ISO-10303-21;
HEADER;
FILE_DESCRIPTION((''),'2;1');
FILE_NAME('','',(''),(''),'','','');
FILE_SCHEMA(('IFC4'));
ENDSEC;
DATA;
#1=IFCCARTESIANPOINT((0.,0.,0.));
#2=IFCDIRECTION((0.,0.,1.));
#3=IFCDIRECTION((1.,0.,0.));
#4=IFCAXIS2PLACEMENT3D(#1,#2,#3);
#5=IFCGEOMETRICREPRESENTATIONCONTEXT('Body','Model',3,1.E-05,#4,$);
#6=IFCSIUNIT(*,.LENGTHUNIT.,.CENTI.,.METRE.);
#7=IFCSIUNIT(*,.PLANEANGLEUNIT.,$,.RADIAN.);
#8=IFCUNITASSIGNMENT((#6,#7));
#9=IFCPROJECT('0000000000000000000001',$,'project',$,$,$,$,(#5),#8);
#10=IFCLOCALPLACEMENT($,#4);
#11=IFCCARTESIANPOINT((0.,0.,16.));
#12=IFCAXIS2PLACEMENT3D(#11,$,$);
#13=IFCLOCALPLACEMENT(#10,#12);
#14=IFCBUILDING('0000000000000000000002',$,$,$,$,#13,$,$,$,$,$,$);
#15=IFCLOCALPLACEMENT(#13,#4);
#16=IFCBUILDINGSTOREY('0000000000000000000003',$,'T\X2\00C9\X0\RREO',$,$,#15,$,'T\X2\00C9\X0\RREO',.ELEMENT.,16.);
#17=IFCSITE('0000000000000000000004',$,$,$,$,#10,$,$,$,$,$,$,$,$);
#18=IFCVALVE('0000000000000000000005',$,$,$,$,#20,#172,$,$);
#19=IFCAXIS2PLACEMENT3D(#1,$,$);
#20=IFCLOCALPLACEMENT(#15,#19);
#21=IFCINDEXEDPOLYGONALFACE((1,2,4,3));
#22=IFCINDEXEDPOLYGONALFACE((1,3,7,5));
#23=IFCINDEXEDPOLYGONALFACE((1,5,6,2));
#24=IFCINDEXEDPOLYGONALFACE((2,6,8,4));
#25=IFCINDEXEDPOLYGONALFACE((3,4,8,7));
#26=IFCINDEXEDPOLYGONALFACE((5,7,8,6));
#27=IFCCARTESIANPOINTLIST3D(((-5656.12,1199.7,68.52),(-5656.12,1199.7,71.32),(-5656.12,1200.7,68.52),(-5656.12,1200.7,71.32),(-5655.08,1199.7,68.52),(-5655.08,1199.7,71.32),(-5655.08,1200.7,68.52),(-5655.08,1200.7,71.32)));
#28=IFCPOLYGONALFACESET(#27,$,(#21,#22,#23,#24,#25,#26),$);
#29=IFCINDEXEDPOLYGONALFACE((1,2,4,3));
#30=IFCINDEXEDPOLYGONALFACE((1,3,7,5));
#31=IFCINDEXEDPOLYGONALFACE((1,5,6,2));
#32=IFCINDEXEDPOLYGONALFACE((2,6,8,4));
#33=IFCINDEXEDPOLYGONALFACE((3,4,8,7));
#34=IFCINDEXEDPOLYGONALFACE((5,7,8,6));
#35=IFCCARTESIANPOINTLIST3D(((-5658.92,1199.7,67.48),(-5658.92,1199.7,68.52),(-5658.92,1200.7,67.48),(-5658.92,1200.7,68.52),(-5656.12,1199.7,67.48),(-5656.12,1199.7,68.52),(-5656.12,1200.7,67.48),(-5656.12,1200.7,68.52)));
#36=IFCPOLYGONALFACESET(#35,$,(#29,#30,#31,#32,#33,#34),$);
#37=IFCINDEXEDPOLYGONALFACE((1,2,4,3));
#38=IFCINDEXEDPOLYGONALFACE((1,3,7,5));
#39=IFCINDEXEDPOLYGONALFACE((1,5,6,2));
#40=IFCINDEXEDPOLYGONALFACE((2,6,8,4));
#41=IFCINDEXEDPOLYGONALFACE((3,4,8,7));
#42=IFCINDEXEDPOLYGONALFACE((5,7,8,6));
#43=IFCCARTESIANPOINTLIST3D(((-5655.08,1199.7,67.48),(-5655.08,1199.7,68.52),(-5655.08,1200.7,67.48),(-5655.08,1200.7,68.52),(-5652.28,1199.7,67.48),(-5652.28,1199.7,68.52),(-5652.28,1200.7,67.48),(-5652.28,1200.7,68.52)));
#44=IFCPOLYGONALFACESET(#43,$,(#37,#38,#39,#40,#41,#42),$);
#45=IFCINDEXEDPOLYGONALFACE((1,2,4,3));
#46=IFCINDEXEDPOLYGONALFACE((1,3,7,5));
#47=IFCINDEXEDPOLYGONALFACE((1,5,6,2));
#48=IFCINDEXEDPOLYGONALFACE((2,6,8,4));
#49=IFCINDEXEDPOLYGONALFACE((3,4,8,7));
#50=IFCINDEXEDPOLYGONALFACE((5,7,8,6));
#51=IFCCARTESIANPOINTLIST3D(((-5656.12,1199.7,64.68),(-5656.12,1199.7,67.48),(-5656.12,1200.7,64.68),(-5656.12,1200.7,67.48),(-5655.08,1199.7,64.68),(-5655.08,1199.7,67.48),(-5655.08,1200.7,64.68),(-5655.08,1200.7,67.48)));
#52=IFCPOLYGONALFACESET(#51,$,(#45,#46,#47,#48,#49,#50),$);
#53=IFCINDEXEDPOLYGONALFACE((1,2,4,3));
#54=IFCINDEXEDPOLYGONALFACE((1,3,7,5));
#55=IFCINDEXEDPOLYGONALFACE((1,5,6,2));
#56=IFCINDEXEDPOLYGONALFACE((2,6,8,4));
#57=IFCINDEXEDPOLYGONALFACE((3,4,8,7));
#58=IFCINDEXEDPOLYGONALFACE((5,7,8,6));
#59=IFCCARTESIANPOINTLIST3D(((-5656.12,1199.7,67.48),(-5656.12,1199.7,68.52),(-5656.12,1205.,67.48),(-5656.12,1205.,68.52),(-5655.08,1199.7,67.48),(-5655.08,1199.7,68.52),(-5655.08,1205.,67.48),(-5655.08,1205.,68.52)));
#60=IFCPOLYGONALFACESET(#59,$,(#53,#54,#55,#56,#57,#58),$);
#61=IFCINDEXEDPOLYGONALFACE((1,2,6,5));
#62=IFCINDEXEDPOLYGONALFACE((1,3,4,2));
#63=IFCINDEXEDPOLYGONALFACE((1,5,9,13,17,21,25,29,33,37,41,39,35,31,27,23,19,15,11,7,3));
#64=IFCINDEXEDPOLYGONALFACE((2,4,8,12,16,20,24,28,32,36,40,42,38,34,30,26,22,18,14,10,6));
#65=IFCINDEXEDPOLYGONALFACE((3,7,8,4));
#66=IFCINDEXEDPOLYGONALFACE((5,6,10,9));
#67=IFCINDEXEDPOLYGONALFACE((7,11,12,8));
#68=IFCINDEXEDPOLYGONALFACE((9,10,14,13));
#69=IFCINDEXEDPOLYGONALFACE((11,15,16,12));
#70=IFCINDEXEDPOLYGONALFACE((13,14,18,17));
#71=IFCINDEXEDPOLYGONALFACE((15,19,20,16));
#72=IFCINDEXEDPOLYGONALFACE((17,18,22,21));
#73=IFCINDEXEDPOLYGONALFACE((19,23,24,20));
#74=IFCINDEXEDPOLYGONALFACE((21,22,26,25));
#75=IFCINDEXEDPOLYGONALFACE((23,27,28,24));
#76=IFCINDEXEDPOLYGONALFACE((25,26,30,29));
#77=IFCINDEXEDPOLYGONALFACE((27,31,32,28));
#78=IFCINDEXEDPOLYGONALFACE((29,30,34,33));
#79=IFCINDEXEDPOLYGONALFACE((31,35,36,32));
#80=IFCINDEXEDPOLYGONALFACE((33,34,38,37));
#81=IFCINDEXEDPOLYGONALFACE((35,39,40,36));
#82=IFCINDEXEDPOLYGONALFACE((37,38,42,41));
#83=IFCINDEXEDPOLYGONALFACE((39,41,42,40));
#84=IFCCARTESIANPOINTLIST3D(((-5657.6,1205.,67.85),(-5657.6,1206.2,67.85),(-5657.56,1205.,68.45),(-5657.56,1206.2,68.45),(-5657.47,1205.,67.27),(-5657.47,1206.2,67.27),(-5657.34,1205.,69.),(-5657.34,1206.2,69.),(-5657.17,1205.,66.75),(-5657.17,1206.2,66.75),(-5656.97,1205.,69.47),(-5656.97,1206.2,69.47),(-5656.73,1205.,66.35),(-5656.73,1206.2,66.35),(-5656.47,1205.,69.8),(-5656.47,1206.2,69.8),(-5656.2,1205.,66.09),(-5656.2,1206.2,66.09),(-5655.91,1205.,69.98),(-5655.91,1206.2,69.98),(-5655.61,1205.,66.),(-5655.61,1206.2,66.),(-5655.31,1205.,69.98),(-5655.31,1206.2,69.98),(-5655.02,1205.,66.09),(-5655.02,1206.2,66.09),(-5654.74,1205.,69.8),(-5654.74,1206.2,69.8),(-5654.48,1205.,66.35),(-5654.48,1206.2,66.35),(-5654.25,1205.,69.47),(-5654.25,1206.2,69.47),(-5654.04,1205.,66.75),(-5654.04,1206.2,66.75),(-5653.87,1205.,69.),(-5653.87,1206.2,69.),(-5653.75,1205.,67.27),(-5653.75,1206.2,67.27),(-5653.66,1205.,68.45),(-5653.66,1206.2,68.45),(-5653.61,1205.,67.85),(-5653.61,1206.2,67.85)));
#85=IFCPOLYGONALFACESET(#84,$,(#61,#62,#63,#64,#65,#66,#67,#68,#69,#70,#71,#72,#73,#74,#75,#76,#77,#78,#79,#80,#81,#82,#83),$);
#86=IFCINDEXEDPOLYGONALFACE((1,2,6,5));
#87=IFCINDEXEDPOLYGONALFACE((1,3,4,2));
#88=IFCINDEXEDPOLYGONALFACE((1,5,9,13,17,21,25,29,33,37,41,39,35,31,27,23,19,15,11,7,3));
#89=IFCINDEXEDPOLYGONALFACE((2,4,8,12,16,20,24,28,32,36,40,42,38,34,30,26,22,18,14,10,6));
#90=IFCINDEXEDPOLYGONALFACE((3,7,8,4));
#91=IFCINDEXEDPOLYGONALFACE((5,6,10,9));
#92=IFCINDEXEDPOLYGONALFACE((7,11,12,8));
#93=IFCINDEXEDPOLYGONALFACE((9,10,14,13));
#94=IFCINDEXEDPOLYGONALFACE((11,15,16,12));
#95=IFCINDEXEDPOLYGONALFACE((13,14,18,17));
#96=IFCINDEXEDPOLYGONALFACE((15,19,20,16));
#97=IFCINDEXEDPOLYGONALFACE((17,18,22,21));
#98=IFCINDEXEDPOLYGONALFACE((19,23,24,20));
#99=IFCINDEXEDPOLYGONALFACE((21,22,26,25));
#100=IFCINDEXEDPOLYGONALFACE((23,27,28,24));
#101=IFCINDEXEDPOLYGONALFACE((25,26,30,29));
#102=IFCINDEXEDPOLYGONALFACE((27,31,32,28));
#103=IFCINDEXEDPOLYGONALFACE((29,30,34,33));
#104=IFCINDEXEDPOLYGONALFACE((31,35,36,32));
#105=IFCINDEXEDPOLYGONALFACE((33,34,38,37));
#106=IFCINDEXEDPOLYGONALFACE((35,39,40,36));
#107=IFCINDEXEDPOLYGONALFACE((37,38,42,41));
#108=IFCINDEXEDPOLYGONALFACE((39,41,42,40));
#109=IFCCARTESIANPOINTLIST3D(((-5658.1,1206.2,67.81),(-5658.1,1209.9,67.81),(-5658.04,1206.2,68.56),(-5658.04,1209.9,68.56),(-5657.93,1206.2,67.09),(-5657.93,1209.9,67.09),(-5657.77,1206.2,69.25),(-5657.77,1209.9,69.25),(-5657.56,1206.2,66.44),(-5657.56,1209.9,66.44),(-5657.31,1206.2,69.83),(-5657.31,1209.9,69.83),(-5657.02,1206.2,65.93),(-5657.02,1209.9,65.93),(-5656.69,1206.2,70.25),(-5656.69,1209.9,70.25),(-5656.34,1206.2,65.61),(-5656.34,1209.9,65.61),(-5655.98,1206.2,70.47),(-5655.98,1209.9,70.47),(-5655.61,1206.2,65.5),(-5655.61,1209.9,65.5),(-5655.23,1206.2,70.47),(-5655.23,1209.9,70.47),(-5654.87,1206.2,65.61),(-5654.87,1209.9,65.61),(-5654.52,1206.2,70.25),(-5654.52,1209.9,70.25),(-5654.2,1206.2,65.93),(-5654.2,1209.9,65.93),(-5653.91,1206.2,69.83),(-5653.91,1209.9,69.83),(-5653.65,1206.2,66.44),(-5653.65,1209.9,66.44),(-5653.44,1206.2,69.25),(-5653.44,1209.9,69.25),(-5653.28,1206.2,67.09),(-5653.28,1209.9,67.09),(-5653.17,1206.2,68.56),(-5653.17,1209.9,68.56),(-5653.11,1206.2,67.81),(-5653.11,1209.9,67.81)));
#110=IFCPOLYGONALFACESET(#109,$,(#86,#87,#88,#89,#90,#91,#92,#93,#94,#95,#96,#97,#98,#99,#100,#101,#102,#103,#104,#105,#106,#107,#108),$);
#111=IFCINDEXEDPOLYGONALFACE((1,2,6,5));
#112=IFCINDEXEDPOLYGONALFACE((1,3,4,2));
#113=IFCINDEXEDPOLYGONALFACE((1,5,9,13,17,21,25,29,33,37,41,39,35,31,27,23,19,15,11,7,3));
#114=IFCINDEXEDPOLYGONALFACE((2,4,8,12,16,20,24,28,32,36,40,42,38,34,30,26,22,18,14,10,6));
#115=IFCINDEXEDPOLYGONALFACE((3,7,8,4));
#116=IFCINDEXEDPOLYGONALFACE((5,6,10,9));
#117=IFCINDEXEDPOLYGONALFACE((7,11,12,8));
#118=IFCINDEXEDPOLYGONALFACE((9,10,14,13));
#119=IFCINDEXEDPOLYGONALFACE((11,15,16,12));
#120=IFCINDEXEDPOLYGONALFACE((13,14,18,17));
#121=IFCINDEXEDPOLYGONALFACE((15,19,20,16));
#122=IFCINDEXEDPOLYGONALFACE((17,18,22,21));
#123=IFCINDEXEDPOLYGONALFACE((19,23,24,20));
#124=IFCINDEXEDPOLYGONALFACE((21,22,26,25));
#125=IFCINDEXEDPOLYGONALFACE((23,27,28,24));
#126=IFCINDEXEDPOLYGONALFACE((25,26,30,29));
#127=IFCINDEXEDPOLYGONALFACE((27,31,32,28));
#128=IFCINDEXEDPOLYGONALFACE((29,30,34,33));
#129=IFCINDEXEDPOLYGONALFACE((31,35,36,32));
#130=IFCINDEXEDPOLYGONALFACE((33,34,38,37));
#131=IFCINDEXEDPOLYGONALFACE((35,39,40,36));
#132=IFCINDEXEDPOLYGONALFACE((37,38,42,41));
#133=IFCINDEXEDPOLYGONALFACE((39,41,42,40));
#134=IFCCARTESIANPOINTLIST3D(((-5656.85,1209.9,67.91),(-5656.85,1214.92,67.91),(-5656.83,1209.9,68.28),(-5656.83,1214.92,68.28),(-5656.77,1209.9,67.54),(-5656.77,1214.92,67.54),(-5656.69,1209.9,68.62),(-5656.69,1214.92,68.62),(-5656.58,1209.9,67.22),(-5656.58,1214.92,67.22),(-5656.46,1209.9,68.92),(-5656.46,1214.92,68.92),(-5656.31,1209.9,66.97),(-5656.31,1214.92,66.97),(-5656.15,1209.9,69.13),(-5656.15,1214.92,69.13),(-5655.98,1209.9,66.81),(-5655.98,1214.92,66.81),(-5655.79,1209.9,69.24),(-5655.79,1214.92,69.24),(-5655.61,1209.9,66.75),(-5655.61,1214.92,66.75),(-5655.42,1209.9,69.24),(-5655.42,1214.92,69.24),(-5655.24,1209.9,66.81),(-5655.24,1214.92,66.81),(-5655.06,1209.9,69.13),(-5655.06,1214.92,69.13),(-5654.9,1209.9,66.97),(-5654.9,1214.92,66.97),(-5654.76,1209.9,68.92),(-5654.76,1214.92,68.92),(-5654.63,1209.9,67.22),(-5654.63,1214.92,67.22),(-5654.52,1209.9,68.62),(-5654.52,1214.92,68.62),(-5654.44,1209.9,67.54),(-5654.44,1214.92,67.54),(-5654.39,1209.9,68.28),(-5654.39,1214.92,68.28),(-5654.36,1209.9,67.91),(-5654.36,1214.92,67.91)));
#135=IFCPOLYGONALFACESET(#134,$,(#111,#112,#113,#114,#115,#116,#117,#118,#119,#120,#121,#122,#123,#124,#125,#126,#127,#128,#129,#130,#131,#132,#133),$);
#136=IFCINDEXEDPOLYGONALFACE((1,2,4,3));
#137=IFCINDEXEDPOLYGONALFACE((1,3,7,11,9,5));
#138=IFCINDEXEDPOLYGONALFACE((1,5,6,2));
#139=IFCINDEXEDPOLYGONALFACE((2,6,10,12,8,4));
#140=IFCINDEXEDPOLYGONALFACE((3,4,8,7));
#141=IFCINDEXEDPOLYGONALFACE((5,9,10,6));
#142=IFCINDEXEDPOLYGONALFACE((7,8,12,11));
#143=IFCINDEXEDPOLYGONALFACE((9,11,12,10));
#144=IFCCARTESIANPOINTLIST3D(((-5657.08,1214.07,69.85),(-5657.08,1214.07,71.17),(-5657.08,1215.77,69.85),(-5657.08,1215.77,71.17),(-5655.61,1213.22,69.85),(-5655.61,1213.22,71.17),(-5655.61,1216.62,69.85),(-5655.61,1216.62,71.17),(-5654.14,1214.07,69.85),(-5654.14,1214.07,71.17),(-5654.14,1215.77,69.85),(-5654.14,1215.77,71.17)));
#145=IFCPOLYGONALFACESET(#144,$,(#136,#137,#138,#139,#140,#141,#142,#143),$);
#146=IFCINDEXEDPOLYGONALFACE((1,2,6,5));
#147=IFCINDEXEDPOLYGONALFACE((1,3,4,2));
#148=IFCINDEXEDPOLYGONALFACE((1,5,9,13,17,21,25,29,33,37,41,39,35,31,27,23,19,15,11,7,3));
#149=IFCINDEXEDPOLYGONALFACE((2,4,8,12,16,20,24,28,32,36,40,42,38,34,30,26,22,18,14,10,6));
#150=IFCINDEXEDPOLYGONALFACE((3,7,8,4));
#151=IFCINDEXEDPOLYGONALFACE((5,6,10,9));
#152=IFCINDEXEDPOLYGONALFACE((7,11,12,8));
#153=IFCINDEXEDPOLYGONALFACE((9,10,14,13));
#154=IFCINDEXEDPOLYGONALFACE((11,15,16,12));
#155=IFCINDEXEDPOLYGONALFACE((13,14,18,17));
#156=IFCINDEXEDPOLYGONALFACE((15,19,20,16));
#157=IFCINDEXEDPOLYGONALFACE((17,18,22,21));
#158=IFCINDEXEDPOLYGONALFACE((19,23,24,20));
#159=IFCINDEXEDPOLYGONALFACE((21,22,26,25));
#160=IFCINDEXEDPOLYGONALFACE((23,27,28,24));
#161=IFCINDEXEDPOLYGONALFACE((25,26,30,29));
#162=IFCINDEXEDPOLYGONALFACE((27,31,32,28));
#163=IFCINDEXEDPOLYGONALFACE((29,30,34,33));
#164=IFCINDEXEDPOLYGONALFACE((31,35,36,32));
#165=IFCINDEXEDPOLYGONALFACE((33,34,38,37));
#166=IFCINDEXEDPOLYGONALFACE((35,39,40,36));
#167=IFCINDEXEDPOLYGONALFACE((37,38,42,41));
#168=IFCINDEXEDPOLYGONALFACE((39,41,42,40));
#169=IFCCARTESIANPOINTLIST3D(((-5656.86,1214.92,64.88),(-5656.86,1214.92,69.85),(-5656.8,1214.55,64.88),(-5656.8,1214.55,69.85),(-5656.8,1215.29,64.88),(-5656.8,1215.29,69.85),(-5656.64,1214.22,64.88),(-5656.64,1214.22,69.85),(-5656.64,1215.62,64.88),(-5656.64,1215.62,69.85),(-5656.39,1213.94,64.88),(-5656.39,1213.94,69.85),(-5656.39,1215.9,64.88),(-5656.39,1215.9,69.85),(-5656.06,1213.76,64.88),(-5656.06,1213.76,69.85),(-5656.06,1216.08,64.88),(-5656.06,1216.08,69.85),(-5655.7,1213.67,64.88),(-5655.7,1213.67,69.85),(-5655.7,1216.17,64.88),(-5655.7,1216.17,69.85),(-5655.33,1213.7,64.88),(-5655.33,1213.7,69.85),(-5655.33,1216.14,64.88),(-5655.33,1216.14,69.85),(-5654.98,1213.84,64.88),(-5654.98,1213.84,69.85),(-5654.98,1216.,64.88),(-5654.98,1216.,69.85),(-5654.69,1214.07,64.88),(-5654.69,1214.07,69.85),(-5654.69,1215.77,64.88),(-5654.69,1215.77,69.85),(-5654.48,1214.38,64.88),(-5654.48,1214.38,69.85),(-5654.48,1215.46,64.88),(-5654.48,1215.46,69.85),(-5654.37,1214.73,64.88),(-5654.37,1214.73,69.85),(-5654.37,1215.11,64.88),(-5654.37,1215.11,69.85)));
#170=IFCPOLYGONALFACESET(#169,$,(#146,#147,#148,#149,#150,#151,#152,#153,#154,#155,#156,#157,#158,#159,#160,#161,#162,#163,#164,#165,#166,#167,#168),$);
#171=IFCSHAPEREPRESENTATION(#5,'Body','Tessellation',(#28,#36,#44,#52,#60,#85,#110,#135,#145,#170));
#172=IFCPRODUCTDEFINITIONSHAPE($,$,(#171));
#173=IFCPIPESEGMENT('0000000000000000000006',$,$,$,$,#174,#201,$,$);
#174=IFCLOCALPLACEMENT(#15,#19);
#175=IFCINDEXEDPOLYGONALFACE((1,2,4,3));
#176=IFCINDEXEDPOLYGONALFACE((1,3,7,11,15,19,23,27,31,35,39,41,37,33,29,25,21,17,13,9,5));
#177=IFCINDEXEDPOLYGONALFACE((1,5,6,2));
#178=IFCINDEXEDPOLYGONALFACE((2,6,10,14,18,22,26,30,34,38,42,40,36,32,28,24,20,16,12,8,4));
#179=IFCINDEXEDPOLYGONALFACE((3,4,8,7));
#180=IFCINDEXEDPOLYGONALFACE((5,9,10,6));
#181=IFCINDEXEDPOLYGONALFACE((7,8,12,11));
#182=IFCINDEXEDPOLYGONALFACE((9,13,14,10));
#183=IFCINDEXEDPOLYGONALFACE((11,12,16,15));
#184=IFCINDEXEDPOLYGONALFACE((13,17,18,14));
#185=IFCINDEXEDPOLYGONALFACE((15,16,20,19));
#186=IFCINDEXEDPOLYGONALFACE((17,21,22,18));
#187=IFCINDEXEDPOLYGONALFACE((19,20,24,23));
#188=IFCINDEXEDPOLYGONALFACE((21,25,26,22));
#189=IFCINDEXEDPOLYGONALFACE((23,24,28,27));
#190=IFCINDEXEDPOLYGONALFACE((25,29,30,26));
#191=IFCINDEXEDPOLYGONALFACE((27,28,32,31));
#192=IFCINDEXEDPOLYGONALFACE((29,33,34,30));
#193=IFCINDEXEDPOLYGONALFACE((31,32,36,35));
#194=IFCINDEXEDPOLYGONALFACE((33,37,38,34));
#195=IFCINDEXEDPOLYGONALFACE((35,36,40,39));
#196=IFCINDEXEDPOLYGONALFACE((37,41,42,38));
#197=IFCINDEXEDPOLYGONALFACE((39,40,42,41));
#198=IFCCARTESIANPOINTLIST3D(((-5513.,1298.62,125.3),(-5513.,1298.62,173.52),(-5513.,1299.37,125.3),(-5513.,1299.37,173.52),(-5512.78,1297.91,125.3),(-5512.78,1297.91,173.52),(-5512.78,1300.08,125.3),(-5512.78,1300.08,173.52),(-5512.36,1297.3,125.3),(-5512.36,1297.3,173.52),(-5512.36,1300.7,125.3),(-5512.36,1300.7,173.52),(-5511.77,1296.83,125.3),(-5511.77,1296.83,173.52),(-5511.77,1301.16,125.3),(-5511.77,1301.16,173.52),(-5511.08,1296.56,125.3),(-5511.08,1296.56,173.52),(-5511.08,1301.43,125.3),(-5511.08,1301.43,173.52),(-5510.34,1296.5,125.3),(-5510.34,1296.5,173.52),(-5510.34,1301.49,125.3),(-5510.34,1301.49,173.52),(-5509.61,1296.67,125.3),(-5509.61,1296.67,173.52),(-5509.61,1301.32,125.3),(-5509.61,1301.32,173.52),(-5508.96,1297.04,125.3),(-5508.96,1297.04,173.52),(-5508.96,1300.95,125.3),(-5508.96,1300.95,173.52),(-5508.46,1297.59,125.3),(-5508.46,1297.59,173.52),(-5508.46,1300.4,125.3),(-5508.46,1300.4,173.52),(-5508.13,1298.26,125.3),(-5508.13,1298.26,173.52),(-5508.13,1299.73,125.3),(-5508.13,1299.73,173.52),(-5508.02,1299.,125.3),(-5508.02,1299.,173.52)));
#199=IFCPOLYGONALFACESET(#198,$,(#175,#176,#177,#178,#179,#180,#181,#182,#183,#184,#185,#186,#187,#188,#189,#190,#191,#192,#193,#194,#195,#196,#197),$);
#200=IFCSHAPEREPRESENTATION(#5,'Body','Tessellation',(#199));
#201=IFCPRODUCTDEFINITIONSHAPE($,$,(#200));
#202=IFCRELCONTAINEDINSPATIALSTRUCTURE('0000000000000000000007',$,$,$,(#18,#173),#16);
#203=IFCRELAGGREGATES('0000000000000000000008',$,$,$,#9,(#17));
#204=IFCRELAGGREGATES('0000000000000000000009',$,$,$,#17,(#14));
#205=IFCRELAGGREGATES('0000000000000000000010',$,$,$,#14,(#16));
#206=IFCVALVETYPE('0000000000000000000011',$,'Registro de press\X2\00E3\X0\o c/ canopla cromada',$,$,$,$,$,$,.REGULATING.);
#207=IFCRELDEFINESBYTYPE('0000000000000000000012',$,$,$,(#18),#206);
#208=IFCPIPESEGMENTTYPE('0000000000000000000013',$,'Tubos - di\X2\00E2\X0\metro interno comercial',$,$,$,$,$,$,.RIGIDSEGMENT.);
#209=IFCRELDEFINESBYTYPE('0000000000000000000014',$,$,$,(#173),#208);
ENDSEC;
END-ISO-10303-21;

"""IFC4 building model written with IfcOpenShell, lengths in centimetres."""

from ifc_helpers import new_model, si_unit, frame, origin_with_axes, origin_2d_with_axis, place, context, project, spatial, polyline, rectangle, circle, outline, extrude, source, transform, mapped, type_object, element, save


model = new_model("IFC4")

# Units and contexts
model_context = context("Model", 3, precision=1e-05, world=origin_with_axes(), identifier="Body")
ifc_project = project(units=[si_unit("LENGTHUNIT", "METRE", prefix="CENTI"), si_unit("PLANEANGLEUNIT", "RADIAN")], contexts=[model_context])

# Site, building, storey
site_placement = place(None, origin_with_axes())
site = spatial("IfcSite", under=ifc_project, at=site_placement)
building_placement = place(site_placement, frame((0.0, 0.0, 16.0)))
building = spatial("IfcBuilding", under=site, at=building_placement)
storey_placement = place(building_placement, origin_with_axes())
storey = spatial("IfcBuildingStorey", under=building, at=storey_placement, Name="TÉRREO", LongName="TÉRREO", CompositionType="ELEMENT", Elevation=16.0)

# Valve
valve_type = type_object("IfcValveType", Name="Registro de pressão c/ canopla cromada", PredefinedType="REGULATING")
shared_shape = source(origin_with_axes(), model_context, "Body", "SolidModel", [
    extrude(rectangle(XDim=1.04, YDim=2.8, at=origin_2d_with_axis()), frame((-1.92, 0.01, 14.22), z_axis=(0.0, 0.0, 1.0), x_axis=(0.0, -1.0, 0.0)), (0.0, 0.0, 1.0), 1.0),
    extrude(rectangle(XDim=1.04, YDim=2.8, at=origin_2d_with_axis()), frame((0.0, -1.91, 14.22), z_axis=(0.0, 0.0, 1.0), x_axis=(1.0, 0.0, 0.0)), (0.0, 0.0, 1.0), 1.0),
    extrude(rectangle(XDim=1.04, YDim=2.8, at=origin_2d_with_axis()), frame((0.0, 1.93, 14.22), z_axis=(0.0, 0.0, 1.0), x_axis=(-1.0, 0.0, 0.0)), (0.0, 0.0, 1.0), 1.0),
    extrude(rectangle(XDim=1.04, YDim=2.8, at=origin_2d_with_axis()), frame((1.92, 0.01, 14.22), z_axis=(0.0, 0.0, 1.0), x_axis=(0.0, 1.0, 0.0)), (0.0, 0.0, 1.0), 1.0),
    extrude(rectangle(XDim=1.04, YDim=1.04, at=origin_2d_with_axis()), frame((0.0, 0.01, 9.92), z_axis=(0.0, 0.0, 1.0), x_axis=(0.0, 1.0, 0.0)), (0.0, 0.0, 1.0), 5.3),
    extrude(circle(Radius=2.0, at=origin_2d_with_axis()), frame((0.0, 0.0, 8.72), z_axis=(0.0, 0.0, 1.0), x_axis=(1.0, 0.0, 0.0)), (0.0, 0.0, 1.0), 1.2),
    extrude(circle(Radius=2.5, at=origin_2d_with_axis()), frame((0.0, 0.0, 5.02), z_axis=(0.0, 0.0, 1.0), x_axis=(1.0, 0.0, 0.0)), (0.0, 0.0, 1.0), 3.7),
    extrude(circle(Radius=1.25, at=origin_2d_with_axis()), origin_with_axes(), (0.0, 0.0, 1.0), 5.02),
    extrude(outline(polyline([(-0.85, -1.47), (0.85, -1.47), (1.7, 0.0), (0.85, 1.47), (-0.85, 1.47), (-1.7, 0.0), (-0.85, -1.47)])), frame((-3.17, 0.0, 0.0), z_axis=(1.0, 0.0, 0.0), x_axis=(0.0, 0.0, -1.0)), (0.0, 0.0, 1.0), 1.32),
    extrude(circle(Radius=1.25, at=origin_2d_with_axis()), frame((-1.85, 0.0, 0.0), z_axis=(1.0, 0.0, 0.0), x_axis=(0.0, -1.0, 0.0)), (0.0, 0.0, 1.0), 4.97),
])
for number, where, z_axis, x_axis in (
    (1, (-5655.61, 1214.92, 68.0), (0.0, -1.0, 0.0), (0.0, 0.0, -1.0)),
):
    element("IfcValve", number, at=place(storey_placement, frame(where, z_axis=z_axis, x_axis=x_axis)), inside=storey, type_object=valve_type, context=model_context, shape_type="MappedRepresentation", body=[
        mapped(shared_shape, transform((0.0, 0.0, 0.0), scale=1.0)),
    ])

# Pipe segment
pipe_segment_type = type_object("IfcPipeSegmentType", Name="Tubos - diâmetro interno comercial", PredefinedType="RIGIDSEGMENT")
pipe_segment_1_placement = place(storey_placement, frame((-5510.52, 1299.0, 173.52), z_axis=(0.0, 0.0, 1.0), x_axis=(1.0, 0.0, 0.0)))
element("IfcPipeSegment", 2, at=pipe_segment_1_placement, inside=storey, type_object=pipe_segment_type, context=model_context, shape_type="SolidModel", body=[
    extrude(circle(Radius=2.5, at=origin_2d_with_axis()), frame((0.0, 0.0, 0.0), z_axis=(0.0, 0.0, -1.0), x_axis=(1.0, 0.0, 0.0)), (0.0, 0.0, 1.0), 48.22),
])

save(model, "model.ifc")
